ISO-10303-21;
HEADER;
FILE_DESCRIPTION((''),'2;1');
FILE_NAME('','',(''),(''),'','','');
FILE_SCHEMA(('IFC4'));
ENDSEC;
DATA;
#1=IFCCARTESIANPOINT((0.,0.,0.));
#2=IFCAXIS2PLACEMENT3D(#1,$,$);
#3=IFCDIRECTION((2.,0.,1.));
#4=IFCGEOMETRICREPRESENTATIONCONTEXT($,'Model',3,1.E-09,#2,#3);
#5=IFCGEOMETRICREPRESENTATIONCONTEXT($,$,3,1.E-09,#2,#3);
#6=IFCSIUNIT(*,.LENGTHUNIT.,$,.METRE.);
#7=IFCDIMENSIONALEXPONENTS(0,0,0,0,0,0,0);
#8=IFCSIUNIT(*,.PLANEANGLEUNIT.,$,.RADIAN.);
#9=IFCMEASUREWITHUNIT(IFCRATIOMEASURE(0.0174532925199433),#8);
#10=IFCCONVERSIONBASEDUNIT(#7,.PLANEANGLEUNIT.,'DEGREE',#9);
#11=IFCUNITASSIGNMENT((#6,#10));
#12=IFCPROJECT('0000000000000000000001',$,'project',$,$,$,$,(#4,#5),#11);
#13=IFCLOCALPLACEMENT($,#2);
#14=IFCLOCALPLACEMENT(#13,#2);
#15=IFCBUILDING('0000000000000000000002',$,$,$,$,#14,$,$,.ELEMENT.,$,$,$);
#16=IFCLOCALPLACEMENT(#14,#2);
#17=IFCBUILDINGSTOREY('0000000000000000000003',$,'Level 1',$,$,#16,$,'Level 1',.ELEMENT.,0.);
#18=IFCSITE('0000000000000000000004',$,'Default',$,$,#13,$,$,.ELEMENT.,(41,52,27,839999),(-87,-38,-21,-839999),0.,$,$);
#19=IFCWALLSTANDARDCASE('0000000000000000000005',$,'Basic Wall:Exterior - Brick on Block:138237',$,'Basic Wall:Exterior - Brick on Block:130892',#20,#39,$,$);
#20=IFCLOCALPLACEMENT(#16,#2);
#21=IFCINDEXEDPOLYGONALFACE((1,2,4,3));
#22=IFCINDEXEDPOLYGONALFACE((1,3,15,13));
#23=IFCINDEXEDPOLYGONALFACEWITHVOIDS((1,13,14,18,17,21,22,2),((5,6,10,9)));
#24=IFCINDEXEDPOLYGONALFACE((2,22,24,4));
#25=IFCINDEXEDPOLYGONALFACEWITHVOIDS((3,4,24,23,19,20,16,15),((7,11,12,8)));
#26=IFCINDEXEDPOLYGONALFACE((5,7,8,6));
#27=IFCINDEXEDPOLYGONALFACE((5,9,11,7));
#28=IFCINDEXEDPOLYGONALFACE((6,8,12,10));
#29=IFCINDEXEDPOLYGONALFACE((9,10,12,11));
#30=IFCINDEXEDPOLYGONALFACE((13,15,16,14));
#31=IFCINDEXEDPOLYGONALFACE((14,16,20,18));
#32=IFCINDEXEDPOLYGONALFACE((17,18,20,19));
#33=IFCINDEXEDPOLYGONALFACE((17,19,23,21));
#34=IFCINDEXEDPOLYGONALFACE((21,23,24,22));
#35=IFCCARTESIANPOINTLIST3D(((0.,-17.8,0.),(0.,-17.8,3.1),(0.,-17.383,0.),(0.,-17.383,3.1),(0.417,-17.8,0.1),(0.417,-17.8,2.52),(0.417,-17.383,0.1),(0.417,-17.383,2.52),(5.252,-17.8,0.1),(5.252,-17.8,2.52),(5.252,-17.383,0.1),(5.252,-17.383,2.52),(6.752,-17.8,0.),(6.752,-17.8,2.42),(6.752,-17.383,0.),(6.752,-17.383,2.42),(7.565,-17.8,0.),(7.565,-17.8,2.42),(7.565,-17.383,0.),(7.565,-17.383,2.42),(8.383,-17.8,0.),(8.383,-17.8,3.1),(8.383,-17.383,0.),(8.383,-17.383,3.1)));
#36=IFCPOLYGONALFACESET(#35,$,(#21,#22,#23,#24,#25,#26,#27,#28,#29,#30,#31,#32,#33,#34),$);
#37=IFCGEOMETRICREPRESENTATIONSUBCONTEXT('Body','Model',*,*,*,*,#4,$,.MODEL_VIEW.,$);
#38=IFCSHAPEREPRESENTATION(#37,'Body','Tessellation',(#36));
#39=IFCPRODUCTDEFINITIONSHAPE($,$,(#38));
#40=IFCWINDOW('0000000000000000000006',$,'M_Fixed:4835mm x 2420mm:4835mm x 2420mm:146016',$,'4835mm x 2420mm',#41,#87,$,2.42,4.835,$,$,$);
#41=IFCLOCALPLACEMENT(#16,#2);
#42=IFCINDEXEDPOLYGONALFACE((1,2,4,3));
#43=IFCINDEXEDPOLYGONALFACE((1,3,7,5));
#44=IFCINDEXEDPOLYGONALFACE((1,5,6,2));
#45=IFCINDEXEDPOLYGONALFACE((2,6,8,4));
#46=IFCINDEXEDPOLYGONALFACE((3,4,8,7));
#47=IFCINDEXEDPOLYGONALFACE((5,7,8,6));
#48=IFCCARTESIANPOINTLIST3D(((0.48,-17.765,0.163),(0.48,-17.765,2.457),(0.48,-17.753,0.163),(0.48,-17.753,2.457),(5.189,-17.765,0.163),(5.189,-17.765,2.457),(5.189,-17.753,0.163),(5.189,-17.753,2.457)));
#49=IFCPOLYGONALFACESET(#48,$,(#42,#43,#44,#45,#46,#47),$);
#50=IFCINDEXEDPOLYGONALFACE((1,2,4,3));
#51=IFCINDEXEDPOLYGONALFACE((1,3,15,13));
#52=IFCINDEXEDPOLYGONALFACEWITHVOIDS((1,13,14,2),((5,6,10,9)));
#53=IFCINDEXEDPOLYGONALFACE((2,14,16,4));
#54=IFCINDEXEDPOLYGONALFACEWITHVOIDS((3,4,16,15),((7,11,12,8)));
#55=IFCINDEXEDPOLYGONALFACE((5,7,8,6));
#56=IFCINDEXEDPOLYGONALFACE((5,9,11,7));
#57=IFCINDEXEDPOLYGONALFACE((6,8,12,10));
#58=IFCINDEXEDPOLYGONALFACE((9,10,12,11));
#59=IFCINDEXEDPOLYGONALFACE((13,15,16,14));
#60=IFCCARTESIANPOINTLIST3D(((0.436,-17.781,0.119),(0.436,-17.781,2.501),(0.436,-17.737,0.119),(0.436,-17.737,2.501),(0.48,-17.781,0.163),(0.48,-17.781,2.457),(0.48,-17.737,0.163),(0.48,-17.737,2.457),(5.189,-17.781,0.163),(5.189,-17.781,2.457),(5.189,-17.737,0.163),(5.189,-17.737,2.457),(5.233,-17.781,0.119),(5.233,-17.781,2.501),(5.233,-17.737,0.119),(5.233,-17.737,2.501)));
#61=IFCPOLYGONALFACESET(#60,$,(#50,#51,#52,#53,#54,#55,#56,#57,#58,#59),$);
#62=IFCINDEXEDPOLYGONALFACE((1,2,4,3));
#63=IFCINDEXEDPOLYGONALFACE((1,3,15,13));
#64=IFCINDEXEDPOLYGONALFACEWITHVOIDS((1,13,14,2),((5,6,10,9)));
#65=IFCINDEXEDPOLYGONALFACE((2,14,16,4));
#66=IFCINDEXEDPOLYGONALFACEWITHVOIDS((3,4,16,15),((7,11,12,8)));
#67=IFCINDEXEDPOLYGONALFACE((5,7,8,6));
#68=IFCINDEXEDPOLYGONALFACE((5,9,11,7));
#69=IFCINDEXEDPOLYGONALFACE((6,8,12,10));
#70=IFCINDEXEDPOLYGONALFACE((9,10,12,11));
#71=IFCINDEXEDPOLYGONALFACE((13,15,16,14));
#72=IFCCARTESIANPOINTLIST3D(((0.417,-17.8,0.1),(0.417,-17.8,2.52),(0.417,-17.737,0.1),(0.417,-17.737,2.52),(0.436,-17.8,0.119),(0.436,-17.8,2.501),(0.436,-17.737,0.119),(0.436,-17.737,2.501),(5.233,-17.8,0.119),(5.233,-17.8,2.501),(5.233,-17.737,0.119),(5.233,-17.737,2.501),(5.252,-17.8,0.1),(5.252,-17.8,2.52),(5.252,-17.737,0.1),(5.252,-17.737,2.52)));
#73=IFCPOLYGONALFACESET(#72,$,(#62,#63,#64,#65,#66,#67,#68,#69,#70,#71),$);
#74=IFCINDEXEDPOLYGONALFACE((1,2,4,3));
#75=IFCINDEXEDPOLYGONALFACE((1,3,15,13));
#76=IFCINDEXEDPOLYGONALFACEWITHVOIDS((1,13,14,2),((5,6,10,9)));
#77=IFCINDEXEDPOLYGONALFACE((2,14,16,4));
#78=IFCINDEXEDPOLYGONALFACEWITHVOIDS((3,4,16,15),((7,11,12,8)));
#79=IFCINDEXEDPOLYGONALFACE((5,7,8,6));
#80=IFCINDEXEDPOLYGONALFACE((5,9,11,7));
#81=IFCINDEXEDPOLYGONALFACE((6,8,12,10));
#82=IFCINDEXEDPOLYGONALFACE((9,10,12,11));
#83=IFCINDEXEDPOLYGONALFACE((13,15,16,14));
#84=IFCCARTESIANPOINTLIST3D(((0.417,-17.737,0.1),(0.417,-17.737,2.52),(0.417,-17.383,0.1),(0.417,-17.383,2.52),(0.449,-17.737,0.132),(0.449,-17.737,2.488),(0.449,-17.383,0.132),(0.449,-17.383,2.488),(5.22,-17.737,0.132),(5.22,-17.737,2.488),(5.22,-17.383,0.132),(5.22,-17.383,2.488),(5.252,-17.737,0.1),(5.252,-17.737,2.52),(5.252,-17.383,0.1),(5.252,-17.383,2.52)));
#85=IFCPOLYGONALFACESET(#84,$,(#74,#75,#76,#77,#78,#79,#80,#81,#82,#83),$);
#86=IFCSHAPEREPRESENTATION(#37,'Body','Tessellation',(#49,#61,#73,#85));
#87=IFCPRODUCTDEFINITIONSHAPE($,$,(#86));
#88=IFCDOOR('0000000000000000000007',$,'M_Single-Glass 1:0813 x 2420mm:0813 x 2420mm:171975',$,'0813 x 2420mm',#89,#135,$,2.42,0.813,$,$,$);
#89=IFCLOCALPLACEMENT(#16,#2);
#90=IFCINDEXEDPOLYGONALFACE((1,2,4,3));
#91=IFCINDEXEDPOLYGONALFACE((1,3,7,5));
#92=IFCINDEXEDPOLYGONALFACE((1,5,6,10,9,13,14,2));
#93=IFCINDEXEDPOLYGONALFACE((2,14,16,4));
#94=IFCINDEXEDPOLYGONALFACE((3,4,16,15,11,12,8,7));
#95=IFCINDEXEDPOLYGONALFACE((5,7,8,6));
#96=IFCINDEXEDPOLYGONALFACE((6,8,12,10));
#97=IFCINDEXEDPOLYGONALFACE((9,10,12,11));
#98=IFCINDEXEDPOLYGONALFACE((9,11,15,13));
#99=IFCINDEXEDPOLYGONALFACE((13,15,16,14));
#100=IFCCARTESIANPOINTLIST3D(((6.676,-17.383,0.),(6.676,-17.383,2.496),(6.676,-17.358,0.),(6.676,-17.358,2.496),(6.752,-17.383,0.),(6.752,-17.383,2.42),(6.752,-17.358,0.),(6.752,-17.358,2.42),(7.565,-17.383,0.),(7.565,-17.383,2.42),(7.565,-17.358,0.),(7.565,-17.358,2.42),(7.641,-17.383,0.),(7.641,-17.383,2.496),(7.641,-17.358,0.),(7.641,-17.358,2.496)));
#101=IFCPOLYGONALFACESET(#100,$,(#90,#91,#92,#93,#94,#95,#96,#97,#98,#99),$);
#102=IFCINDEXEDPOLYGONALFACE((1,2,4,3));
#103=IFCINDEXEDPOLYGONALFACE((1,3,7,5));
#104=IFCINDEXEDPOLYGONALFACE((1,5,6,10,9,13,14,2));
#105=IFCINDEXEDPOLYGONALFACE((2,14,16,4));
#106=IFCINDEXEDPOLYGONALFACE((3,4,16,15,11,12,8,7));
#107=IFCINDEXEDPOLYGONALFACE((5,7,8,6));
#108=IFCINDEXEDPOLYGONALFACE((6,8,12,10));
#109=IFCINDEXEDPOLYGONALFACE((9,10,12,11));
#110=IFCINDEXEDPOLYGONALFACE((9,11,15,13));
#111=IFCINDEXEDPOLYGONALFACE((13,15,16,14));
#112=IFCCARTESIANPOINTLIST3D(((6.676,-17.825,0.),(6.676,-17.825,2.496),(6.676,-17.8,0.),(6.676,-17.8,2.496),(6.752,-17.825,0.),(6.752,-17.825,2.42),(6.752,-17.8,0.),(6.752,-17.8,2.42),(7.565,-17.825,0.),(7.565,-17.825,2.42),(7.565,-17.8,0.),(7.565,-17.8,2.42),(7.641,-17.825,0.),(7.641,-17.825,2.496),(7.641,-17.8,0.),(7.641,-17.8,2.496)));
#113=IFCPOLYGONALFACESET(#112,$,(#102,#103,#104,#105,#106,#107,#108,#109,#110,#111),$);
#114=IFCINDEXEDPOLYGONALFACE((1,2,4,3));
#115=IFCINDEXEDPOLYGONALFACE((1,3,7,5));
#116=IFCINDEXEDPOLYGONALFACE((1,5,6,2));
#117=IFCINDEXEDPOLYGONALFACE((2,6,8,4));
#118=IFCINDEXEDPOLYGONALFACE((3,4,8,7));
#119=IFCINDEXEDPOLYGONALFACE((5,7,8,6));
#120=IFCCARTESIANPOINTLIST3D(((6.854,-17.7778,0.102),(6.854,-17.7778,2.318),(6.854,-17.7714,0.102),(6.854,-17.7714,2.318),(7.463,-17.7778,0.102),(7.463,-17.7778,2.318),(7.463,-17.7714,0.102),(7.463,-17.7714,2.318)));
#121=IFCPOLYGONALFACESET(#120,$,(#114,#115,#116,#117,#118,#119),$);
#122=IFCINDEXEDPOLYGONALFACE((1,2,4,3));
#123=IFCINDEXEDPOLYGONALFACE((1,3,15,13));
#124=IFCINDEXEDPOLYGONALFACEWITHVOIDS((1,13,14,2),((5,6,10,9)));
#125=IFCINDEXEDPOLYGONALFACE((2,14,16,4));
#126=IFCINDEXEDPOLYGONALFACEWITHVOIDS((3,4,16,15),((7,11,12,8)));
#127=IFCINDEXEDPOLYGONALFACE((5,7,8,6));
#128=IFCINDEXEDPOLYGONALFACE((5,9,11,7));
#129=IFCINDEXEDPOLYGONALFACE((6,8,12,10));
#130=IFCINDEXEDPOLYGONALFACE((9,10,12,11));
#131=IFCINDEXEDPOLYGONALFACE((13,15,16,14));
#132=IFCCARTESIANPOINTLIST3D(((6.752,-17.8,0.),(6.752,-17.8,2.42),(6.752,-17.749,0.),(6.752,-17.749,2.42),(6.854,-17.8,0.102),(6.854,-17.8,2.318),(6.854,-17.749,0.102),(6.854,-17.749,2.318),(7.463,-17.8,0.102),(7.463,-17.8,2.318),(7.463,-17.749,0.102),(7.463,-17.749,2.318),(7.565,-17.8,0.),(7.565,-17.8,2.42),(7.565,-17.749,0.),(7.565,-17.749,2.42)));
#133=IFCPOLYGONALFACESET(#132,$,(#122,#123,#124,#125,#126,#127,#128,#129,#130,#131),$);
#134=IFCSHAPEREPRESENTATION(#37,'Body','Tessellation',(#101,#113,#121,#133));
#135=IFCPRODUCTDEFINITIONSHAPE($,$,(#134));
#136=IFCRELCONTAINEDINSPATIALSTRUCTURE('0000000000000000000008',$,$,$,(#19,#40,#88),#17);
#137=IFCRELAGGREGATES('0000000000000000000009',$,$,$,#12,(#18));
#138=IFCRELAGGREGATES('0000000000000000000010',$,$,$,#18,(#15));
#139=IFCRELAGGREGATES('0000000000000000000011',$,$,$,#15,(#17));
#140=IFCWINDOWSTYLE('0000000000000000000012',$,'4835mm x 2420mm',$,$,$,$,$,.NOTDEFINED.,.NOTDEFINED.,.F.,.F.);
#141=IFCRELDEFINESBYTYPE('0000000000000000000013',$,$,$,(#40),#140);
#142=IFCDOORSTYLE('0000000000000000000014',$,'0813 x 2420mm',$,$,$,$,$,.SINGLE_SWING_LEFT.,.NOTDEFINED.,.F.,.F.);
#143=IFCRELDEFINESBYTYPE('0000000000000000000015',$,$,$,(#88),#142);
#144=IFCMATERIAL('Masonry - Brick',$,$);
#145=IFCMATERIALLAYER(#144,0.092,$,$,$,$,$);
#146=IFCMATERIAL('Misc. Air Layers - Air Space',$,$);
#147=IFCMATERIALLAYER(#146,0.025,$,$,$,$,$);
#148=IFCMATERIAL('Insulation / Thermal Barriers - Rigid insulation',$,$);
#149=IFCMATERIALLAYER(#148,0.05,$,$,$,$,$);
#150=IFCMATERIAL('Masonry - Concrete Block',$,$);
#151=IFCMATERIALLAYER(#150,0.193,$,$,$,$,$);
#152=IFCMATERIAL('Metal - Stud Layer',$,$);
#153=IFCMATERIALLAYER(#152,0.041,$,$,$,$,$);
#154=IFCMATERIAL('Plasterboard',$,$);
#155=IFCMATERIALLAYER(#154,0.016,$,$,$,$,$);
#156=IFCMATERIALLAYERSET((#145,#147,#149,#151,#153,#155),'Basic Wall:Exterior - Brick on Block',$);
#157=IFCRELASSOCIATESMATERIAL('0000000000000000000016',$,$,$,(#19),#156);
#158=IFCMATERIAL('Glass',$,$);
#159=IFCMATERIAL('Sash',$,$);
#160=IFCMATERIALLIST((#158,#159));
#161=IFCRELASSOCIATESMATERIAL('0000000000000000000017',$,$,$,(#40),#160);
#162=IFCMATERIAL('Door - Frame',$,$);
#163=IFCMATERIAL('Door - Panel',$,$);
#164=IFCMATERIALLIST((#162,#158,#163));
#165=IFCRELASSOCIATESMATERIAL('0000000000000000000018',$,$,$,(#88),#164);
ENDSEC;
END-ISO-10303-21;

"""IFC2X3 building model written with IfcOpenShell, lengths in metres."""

from ifc_helpers import new_model, entity, si_unit, converted_unit, direction, frame, frame_2d, origin, origin_2d_with_axis, place, context, subcontext, project, spatial, polyline, rectangle, outline, extrude, source, transform, mapped, material, material_list, layer, layer_set, layer_usage, type_object, type_shapes, element, fill, save


model = new_model("IFC2X3")

# Units and contexts
model_context = context("Model", 3, precision=1e-09, world=origin(), true_north=direction((2.0, 0.0, 1.0)))
context_of_model = context(None, 3, precision=1e-09, world=origin(), true_north=direction((2.0, 0.0, 1.0)))
body_context = subcontext(model_context, "Body", "Model", "MODEL_VIEW")
ifc_project = project(units=[si_unit("LENGTHUNIT", "METRE"), converted_unit("PLANEANGLEUNIT", "DEGREE", entity("IfcRatioMeasure", 0.0174532925199433), si_unit("PLANEANGLEUNIT", "RADIAN"), dimensions=[0, 0, 0, 0, 0, 0, 0])], contexts=[model_context, context_of_model])

# Site, building, storey
site_placement = place(None, origin())
site = spatial("IfcSite", under=ifc_project, at=site_placement, Name="Default", CompositionType="ELEMENT", RefLatitude=(41, 52, 27, 839999), RefLongitude=(-87, -38, -21, -839999), RefElevation=0.0)
building_placement = place(site_placement, origin())
building = spatial("IfcBuilding", under=site, at=building_placement, CompositionType="ELEMENT")
storey_placement = place(building_placement, origin())
storey = spatial("IfcBuildingStorey", under=building, at=storey_placement, Name="Level 1", LongName="Level 1", CompositionType="ELEMENT", Elevation=0.0)

# Wall, openings, window, door
ifc_material_1 = material(Name="Masonry - Brick")
ifc_layer_1 = layer(ifc_material_1, 0.092)
ifc_material_2 = material(Name="Misc. Air Layers - Air Space")
ifc_layer_2 = layer(ifc_material_2, 0.025)
ifc_material_3 = material(Name="Insulation / Thermal Barriers - Rigid insulation")
ifc_layer_3 = layer(ifc_material_3, 0.05)
ifc_material_4 = material(Name="Masonry - Concrete Block")
ifc_layer_4 = layer(ifc_material_4, 0.193)
ifc_material_5 = material(Name="Metal - Stud Layer")
ifc_layer_5 = layer(ifc_material_5, 0.041)
ifc_material_6 = material(Name="Plasterboard")
ifc_layer_6 = layer(ifc_material_6, 0.016)
ifc_layer_set_1 = layer_set([ifc_layer_1, ifc_layer_2, ifc_layer_3, ifc_layer_4, ifc_layer_5, ifc_layer_6], Name="Basic Wall:Exterior - Brick on Block")
ifc_layer_usage_1 = layer_usage(ifc_layer_set_1, "AXIS2", "NEGATIVE", 0.2085)
wall_1_placement = place(storey_placement, frame((8.383, -17.5915, 0.0), z_axis=(0.0, 0.0, 1.0), x_axis=(-1.0, 0.0, 0.0)))
wall_1 = element("IfcWallStandardCase", 1, at=wall_1_placement, inside=storey, material=ifc_layer_usage_1, Name="Basic Wall:Exterior - Brick on Block:138237", ObjectType="Basic Wall:Exterior - Brick on Block:130892", context=body_context, shape_type="SweptSolid", body=[
    extrude(rectangle(XDim=8.383, YDim=0.417, at=frame_2d((4.1915, 0.0), x_axis=(-1.0, 0.0))), origin(), (0.0, 0.0, 1.0), 3.1),
])
opening_1_placement = place(wall_1_placement, frame((3.131, -0.2085, 0.1)))
opening_1 = element("IfcOpeningElement", 2, at=opening_1_placement, cuts=wall_1, ObjectType="Opening", context=body_context, shape_type="SweptSolid", body=[
    extrude(rectangle(XDim=2.42, YDim=4.835, at=frame_2d((1.21, 2.4175), x_axis=(1.0, 0.0))), frame((0.0, 0.0, 0.0), z_axis=(0.0, 1.0, 0.0), x_axis=(0.0, 0.0, 1.0)), (0.0, 0.0, 1.0), 0.417),
])
opening_2_placement = place(wall_1_placement, frame((0.818, -0.2085, 0.0)))
opening_2 = element("IfcOpeningElement", 3, at=opening_2_placement, cuts=wall_1, ObjectType="Opening", context=body_context, shape_type="SweptSolid", body=[
    extrude(rectangle(XDim=0.813, YDim=2.42, at=frame_2d((1.21, 0.4065), x_axis=(0.0, -1.0))), frame((0.0, 0.0, 0.0), z_axis=(0.0, 1.0, 0.0), x_axis=(0.0, 0.0, 1.0)), (0.0, 0.0, 1.0), 0.417),
])
ifc_material_7 = material(Name="Glass")
ifc_material_8 = material(Name="Sash")
ifc_material_list_1 = material_list([ifc_material_7, ifc_material_8])
window_style_1 = type_object("IfcWindowStyle", Name="4835mm x 2420mm", ConstructionType="NOTDEFINED", OperationType="NOTDEFINED", ParameterTakesPrecedence=False, Sizeable=False)
shared_shape_1 = source(origin(), body_context, "Body", "SweptSolid", [
    extrude(rectangle(XDim=0.012, YDim=4.709, at=origin_2d_with_axis()), frame((2.4175, 0.376, 0.063), z_axis=(0.0, 0.0, 1.0), x_axis=(0.0, -1.0, 0.0)), (0.0, 0.0, 1.0), 2.294),
    extrude(outline(polyline([(-2.3985, -1.191), (2.3985, -1.191), (2.3985, 1.191), (-2.3985, 1.191), (-2.3985, -1.191)]), holes=[polyline([(-2.3545, -1.147), (-2.3545, 1.147), (2.3545, 1.147), (2.3545, -1.147), (-2.3545, -1.147)])]), frame((2.4175, 0.354, 1.21), z_axis=(0.0, 1.0, 0.0), x_axis=(1.0, 0.0, 0.0)), (0.0, 0.0, 1.0), 0.044),
    extrude(outline(polyline([(-2.4175, -1.21), (2.4175, -1.21), (2.4175, 1.21), (-2.4175, 1.21), (-2.4175, -1.21)]), holes=[polyline([(-2.3985, -1.191), (-2.3985, 1.191), (2.3985, 1.191), (2.3985, -1.191), (-2.3985, -1.191)])]), frame((2.4175, 0.354, 1.21), z_axis=(0.0, 1.0, 0.0), x_axis=(1.0, 0.0, 0.0)), (0.0, 0.0, 1.0), 0.063),
    extrude(outline(polyline([(-2.4175, -1.21), (2.4175, -1.21), (2.4175, 1.21), (-2.4175, 1.21), (-2.4175, -1.21)]), holes=[polyline([(-2.3855, -1.178), (-2.3855, 1.178), (2.3855, 1.178), (2.3855, -1.178), (-2.3855, -1.178)])]), frame((2.4175, 0.0, 1.21), z_axis=(0.0, 1.0, 0.0), x_axis=(1.0, 0.0, 0.0)), (0.0, 0.0, 1.0), 0.354),
])
type_shapes(window_style_1, [shared_shape_1])
window_1_placement = place(opening_1_placement, origin())
window_1 = element("IfcWindow", 4, at=window_1_placement, inside=storey, type_object=window_style_1, material=ifc_material_list_1, Name="M_Fixed:4835mm x 2420mm:4835mm x 2420mm:146016", ObjectType="4835mm x 2420mm", OverallHeight=2.42, OverallWidth=4.835, context=body_context, shape_type="MappedRepresentation", body=[
    mapped(shared_shape_1, transform((0.0, 0.0, 0.0), scale=1.0)),
])
fill(opening_1, window_1)
ifc_material_9 = material(Name="Door - Frame")
ifc_material_10 = material(Name="Door - Panel")
ifc_material_list_2 = material_list([ifc_material_9, ifc_material_7, ifc_material_10])
door_style_1 = type_object("IfcDoorStyle", Name="0813 x 2420mm", ConstructionType="NOTDEFINED", OperationType="SINGLE_SWING_LEFT", ParameterTakesPrecedence=False, Sizeable=False)
shared_shape_2 = source(origin(), body_context, "Body", "SweptSolid", [
    extrude(outline(polyline([(-0.4065, -1.191), (-0.4065, 1.229), (-0.4825, 1.229), (-0.4825, -1.267), (0.4825, -1.267), (0.4825, 1.229), (0.4065, 1.229), (0.4065, -1.191), (-0.4065, -1.191)])), frame((0.4065, 0.0, 1.229), z_axis=(0.0, 1.0, 0.0), x_axis=(1.0, 0.0, 0.0)), (0.0, 0.0, -1.0), 0.025),
    extrude(outline(polyline([(-0.4065, -1.191), (-0.4065, 1.229), (-0.4825, 1.229), (-0.4825, -1.267), (0.4825, -1.267), (0.4825, 1.229), (0.4065, 1.229), (0.4065, -1.191), (-0.4065, -1.191)])), frame((0.4065, 0.442, 1.229), z_axis=(0.0, 1.0, 0.0), x_axis=(1.0, 0.0, 0.0)), (0.0, 0.0, -1.0), 0.025),
    extrude(rectangle(XDim=0.609, YDim=0.0064, at=frame_2d((0.0, 0.0), x_axis=(1.0, 0.0))), frame((0.4065, 0.3916, 0.102)), (0.0, 0.0, 1.0), 2.216),
    extrude(outline(polyline([(-1.21, -0.4065), (1.21, -0.4065), (1.21, 0.4065), (-1.21, 0.4065), (-1.21, -0.4065)]), holes=[polyline([(-1.108, 0.3045), (1.108, 0.3045), (1.108, -0.3045), (-1.108, -0.3045), (-1.108, 0.3045)])]), frame((0.4065, 0.417, 1.21), z_axis=(0.0, -1.0, 0.0), x_axis=(0.0, 0.0, -1.0)), (0.0, 0.0, 1.0), 0.051),
])
type_shapes(door_style_1, [shared_shape_2])
door_1_placement = place(opening_2_placement, origin())
door_1 = element("IfcDoor", 5, at=door_1_placement, inside=storey, type_object=door_style_1, material=ifc_material_list_2, Name="M_Single-Glass 1:0813 x 2420mm:0813 x 2420mm:171975", ObjectType="0813 x 2420mm", OverallHeight=2.42, OverallWidth=0.813, context=body_context, shape_type="MappedRepresentation", body=[
    mapped(shared_shape_2, transform((0.0, 0.0, 0.0), scale=1.0)),
])
fill(opening_2, door_1)

save(model, "model.ifc")
